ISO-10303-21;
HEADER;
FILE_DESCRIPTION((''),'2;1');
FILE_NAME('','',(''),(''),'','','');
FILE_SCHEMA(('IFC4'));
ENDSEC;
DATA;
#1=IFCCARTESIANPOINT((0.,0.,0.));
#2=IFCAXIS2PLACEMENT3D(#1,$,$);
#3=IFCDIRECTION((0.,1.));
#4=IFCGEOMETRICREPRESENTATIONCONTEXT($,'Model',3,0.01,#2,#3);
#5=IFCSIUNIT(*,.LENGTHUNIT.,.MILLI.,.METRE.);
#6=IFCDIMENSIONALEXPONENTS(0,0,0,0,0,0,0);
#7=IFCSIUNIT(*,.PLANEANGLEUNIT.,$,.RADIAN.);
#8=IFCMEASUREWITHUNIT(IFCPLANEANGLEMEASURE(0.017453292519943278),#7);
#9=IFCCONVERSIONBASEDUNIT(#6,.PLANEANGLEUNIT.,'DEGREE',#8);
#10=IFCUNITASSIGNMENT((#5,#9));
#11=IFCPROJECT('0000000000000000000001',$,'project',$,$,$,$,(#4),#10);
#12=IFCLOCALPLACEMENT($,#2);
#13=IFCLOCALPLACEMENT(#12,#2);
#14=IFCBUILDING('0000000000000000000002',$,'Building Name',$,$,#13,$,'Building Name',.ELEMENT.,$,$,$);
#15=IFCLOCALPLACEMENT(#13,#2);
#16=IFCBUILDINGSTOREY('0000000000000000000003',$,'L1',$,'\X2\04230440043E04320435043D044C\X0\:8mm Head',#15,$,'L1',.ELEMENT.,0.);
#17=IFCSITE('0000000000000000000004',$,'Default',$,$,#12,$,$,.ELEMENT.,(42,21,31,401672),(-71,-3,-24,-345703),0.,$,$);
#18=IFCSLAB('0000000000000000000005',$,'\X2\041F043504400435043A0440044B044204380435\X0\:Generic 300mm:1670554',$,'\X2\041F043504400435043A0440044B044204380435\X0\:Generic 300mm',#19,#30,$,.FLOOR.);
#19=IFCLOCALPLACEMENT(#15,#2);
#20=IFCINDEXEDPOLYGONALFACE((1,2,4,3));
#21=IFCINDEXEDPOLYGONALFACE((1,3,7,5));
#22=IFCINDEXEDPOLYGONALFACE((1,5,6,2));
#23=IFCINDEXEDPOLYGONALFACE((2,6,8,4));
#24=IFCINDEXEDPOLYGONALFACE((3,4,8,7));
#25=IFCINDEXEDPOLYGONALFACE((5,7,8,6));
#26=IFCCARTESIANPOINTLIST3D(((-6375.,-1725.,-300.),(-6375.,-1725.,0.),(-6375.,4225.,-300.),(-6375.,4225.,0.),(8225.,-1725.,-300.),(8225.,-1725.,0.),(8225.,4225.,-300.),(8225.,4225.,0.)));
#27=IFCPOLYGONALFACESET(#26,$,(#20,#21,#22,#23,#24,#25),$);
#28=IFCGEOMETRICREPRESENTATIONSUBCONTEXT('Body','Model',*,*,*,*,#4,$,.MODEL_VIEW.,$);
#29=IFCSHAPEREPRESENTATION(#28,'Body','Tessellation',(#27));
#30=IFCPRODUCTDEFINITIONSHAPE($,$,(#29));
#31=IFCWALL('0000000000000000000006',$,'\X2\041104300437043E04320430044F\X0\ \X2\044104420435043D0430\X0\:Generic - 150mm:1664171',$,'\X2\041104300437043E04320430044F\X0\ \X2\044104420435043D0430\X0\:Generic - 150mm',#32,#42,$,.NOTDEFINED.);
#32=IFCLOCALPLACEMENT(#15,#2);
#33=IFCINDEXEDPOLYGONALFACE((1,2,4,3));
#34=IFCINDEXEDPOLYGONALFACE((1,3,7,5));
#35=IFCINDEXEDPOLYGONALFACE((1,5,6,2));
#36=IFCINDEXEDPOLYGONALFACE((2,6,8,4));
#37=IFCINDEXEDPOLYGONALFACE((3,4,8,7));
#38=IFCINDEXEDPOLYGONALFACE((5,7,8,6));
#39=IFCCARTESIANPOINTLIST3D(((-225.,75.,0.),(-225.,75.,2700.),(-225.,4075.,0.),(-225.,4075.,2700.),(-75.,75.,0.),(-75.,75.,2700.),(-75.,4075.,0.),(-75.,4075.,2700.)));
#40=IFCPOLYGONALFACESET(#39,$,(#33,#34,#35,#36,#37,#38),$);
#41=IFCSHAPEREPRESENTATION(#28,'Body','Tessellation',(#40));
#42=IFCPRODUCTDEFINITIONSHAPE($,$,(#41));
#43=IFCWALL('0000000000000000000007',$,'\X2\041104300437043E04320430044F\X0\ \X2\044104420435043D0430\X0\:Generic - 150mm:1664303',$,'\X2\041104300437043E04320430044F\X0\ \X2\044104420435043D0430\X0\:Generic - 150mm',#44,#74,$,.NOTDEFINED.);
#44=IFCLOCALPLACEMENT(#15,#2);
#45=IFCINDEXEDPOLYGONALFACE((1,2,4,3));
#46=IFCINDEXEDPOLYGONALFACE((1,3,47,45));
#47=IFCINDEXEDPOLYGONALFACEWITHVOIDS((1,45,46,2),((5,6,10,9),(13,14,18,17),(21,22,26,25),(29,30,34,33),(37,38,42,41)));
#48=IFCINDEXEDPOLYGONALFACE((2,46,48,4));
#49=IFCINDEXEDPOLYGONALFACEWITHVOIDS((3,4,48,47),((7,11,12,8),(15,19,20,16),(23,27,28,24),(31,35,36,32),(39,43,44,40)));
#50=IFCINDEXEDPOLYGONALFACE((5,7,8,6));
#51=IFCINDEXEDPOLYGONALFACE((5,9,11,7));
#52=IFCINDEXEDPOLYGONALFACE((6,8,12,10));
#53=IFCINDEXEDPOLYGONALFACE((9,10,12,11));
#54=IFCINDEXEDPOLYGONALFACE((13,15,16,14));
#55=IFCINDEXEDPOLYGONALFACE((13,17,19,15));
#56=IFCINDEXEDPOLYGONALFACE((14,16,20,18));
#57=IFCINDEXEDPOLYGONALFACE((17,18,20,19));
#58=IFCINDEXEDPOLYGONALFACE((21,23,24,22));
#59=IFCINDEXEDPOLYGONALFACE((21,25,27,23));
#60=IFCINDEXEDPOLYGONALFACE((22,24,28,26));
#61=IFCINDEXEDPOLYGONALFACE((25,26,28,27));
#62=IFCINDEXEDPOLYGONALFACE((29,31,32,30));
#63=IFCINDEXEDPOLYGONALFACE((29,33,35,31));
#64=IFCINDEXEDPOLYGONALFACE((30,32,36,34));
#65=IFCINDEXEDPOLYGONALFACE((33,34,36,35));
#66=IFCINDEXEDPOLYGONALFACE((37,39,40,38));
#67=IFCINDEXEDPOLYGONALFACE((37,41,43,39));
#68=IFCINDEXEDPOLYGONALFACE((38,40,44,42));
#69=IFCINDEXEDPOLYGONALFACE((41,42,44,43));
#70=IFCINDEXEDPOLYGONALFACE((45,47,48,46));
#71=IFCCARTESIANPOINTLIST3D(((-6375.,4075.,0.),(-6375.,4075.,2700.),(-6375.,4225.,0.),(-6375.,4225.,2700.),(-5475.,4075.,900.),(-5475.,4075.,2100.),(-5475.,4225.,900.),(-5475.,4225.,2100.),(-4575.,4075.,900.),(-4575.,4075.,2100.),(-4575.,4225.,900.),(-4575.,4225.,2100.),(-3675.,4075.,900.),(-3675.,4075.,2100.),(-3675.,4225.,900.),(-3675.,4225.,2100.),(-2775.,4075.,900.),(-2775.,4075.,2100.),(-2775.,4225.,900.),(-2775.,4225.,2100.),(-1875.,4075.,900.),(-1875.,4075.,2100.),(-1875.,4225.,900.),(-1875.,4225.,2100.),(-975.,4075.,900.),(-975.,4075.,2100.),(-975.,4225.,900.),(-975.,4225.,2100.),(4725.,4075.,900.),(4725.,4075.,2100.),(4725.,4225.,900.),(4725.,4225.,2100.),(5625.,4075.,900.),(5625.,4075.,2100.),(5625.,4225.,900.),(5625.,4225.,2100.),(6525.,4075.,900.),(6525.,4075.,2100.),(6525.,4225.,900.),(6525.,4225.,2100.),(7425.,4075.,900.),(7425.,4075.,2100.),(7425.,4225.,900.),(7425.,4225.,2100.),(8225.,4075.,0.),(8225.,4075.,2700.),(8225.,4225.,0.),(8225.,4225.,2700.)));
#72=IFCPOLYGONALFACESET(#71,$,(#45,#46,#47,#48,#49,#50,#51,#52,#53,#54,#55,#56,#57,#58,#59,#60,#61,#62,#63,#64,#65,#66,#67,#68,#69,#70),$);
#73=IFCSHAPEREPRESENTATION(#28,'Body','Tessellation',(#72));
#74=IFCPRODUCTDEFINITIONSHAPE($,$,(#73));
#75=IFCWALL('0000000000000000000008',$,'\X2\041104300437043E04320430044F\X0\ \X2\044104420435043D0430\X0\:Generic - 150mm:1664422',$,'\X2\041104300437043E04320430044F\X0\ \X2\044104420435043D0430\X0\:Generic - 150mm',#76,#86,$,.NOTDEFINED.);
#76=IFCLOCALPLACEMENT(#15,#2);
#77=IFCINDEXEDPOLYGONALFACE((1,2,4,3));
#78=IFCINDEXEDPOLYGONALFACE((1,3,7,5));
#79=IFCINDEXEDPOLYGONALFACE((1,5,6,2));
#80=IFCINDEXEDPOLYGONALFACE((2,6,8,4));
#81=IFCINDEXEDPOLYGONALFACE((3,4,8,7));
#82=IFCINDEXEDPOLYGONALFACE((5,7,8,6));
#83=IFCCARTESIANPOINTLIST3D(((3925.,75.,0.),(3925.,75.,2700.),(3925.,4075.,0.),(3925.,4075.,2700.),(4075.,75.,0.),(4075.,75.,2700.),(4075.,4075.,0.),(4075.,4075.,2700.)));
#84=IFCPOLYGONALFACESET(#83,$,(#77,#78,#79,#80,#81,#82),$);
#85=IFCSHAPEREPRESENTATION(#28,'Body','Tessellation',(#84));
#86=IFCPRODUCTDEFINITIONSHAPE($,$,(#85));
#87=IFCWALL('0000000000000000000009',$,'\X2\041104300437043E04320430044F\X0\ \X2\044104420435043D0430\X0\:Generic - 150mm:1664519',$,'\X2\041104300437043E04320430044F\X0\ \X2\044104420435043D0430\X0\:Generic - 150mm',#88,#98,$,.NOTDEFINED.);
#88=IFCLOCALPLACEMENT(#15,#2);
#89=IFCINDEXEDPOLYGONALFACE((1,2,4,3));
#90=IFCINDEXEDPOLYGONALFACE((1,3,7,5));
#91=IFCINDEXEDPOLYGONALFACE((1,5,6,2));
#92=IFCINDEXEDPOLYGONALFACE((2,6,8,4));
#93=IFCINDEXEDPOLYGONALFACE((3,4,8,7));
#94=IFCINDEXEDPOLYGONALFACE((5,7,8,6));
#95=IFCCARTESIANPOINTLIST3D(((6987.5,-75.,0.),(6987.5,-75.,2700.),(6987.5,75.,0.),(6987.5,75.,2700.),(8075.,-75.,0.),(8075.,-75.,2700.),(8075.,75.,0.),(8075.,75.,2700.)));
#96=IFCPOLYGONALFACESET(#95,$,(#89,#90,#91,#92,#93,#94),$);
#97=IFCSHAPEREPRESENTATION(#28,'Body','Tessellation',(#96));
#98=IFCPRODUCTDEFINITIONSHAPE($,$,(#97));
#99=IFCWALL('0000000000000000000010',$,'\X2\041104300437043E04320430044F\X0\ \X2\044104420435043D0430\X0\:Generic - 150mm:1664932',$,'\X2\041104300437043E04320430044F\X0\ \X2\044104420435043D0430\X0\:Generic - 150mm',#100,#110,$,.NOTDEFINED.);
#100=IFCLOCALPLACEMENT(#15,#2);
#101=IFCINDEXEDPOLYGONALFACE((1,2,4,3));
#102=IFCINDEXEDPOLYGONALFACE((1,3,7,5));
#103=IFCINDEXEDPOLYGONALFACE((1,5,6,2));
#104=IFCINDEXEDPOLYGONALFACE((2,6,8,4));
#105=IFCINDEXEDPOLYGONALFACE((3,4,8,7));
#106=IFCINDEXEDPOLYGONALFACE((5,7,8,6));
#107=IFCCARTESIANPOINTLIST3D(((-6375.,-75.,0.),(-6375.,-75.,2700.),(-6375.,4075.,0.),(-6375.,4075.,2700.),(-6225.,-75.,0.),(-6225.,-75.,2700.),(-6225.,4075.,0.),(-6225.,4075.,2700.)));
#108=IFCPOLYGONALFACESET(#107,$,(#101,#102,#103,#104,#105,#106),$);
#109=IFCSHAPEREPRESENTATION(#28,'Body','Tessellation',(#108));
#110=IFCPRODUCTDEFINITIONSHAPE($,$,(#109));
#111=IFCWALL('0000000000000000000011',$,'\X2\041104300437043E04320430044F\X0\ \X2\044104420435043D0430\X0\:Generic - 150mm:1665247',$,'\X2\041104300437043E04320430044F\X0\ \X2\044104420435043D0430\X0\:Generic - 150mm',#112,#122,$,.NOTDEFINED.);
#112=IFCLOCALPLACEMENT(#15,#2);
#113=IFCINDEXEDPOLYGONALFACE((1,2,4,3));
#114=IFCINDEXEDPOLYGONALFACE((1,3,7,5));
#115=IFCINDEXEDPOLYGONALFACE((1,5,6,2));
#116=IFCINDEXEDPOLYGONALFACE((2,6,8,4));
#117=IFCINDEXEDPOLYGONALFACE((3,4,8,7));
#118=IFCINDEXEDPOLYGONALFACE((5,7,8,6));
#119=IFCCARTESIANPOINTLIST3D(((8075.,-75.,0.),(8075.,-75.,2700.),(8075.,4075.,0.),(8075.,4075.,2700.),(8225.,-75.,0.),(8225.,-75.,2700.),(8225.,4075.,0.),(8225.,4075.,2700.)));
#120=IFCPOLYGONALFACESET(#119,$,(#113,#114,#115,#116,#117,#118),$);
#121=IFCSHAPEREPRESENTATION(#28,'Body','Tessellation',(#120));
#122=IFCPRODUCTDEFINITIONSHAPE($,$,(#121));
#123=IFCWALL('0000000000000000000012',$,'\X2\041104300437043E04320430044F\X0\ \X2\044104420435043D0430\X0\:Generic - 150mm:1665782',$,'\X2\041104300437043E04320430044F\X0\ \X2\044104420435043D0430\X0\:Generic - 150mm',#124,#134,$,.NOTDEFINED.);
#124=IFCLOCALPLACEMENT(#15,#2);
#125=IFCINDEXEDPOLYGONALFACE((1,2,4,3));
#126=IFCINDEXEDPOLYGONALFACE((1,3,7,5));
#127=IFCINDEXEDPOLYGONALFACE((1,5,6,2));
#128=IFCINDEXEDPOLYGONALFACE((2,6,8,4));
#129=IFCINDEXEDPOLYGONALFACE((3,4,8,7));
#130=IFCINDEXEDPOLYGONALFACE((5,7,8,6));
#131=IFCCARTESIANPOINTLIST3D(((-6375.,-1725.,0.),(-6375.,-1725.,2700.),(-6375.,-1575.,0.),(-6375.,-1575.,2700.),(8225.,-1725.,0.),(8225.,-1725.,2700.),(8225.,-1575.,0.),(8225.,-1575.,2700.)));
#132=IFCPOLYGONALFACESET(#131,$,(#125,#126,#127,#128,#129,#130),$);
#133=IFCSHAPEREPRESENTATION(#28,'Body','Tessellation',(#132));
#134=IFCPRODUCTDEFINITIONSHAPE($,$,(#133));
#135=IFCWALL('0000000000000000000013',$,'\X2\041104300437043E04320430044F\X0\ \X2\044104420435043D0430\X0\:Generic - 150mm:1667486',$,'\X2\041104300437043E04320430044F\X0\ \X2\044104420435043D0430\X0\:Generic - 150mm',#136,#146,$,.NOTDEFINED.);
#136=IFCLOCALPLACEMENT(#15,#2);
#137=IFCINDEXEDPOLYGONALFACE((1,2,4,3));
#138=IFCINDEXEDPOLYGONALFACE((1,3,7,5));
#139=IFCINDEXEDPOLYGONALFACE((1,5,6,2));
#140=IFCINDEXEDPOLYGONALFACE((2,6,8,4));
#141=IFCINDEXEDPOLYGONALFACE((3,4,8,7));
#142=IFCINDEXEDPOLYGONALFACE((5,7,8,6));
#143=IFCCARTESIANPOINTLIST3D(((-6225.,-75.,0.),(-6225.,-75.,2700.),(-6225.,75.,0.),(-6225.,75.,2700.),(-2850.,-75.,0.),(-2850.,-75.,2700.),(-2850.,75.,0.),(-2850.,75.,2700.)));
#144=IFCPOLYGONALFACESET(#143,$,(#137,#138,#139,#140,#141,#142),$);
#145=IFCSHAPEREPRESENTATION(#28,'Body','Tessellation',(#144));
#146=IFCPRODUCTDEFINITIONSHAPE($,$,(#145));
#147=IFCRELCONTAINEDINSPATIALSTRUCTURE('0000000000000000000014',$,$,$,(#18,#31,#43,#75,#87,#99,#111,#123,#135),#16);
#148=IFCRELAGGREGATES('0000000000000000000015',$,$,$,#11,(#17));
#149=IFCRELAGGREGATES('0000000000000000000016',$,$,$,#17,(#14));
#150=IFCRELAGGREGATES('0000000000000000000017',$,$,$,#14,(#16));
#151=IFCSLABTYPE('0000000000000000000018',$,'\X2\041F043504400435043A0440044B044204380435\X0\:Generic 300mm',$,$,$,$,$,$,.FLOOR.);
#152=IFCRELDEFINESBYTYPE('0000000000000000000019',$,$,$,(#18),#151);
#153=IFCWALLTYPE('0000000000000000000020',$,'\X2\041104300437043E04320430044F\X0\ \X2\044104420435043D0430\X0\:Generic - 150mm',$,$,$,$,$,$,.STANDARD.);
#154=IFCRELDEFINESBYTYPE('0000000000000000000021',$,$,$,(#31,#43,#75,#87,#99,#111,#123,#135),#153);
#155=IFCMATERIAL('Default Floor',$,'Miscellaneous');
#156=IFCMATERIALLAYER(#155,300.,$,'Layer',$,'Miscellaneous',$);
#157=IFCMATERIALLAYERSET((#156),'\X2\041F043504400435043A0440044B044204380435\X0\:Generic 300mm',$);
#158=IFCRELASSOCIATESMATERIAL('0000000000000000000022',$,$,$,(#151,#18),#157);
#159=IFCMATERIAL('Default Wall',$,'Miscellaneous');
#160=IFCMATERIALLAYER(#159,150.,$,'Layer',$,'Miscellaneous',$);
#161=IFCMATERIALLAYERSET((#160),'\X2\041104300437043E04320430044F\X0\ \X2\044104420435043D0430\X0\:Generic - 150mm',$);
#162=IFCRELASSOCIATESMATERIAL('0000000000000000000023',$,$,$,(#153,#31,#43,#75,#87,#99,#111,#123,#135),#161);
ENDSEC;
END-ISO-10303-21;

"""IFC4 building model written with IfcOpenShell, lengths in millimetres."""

from ifc_helpers import new_model, entity, si_unit, converted_unit, direction, frame, frame_2d, origin, origin_2d_with_axis, place, context, subcontext, project, spatial, rectangle, extrude, material, layer, layer_set, layer_usage, type_object, element, save


model = new_model("IFC4")

# Units and contexts
model_context = context("Model", 3, precision=0.01, world=origin(), true_north=direction((0.0, 1.0)))
body_context = subcontext(model_context, "Body", "Model", "MODEL_VIEW")
ifc_project = project(units=[si_unit("LENGTHUNIT", "METRE", prefix="MILLI"), converted_unit("PLANEANGLEUNIT", "DEGREE", entity("IfcPlaneAngleMeasure", 0.017453292519943278), si_unit("PLANEANGLEUNIT", "RADIAN"), dimensions=[0, 0, 0, 0, 0, 0, 0])], contexts=[model_context])

# Site, building, storey
site_placement = place(None, origin())
site = spatial("IfcSite", under=ifc_project, at=site_placement, Name="Default", CompositionType="ELEMENT", RefLatitude=(42, 21, 31, 401672), RefLongitude=(-71, -3, -24, -345703), RefElevation=0.0)
building_placement = place(site_placement, origin())
building = spatial("IfcBuilding", under=site, at=building_placement, Name="Building Name", LongName="Building Name", CompositionType="ELEMENT")
storey_placement = place(building_placement, origin())
storey = spatial("IfcBuildingStorey", under=building, at=storey_placement, Name="L1", ObjectType="Уровень:8mm Head", LongName="L1", CompositionType="ELEMENT", Elevation=0.0)

# Slab
ifc_material_1 = material(Name="Default Floor", Category="Miscellaneous")
ifc_layer_1 = layer(ifc_material_1, 300.0, Name="Layer", Category="Miscellaneous")
ifc_layer_set_1 = layer_set([ifc_layer_1], Name="Перекрытие:Generic 300mm")
ifc_layer_usage_1 = layer_usage(ifc_layer_set_1, "AXIS3", "POSITIVE", 0.0)
slab_type = type_object("IfcSlabType", Name="Перекрытие:Generic 300mm", PredefinedType="FLOOR", material=ifc_layer_set_1)
slab_placement = place(storey_placement, origin())
element("IfcSlab", 1, at=slab_placement, inside=storey, type_object=slab_type, material=ifc_layer_usage_1, Name="Перекрытие:Generic 300mm:1670554", ObjectType="Перекрытие:Generic 300mm", PredefinedType="FLOOR", context=body_context, shape_type="SweptSolid", body=[
    extrude(rectangle(XDim=5950.0, YDim=14600.0, at=origin_2d_with_axis()), frame((925.0, 1250.0, 0.0), z_axis=(0.0, 0.0, -1.0), x_axis=(0.0, 1.0, 0.0)), (0.0, 0.0, 1.0), 300.0),
])

# Wall
ifc_material_2 = material(Name="Default Wall", Category="Miscellaneous")
ifc_layer_2 = layer(ifc_material_2, 150.0, Name="Layer", Category="Miscellaneous")
ifc_layer_set_2 = layer_set([ifc_layer_2], Name="Базовая стена:Generic - 150mm")
ifc_layer_usage_2 = layer_usage(ifc_layer_set_2, "AXIS2", "NEGATIVE", 75.0)
wall_type = type_object("IfcWallType", Name="Базовая стена:Generic - 150mm", PredefinedType="STANDARD", material=ifc_layer_set_2)
wall_1_placement = place(storey_placement, frame((-150.0, 75.0, 0.0), z_axis=(0.0, 0.0, 1.0), x_axis=(0.0, 1.0, 0.0)))
element("IfcWall", 2, at=wall_1_placement, inside=storey, type_object=wall_type, material=ifc_layer_usage_2, Name="Базовая стена:Generic - 150mm:1664171", ObjectType="Базовая стена:Generic - 150mm", PredefinedType="NOTDEFINED", context=body_context, shape_type="SweptSolid", body=[
    extrude(rectangle(XDim=4000.0, YDim=150.0, at=frame_2d((2000.0, 0.0), x_axis=(-1.0, 0.0))), origin(), (0.0, 0.0, 1.0), 2700.0),
])

# Wall, openings
ifc_layer_usage_3 = layer_usage(ifc_layer_set_2, "AXIS2", "NEGATIVE", 75.0)
wall_2_placement = place(storey_placement, frame((-6375.0, 4150.0, 0.0)))
wall_2 = element("IfcWall", 3, at=wall_2_placement, inside=storey, type_object=wall_type, material=ifc_layer_usage_3, Name="Базовая стена:Generic - 150mm:1664303", ObjectType="Базовая стена:Generic - 150mm", PredefinedType="NOTDEFINED", context=body_context, shape_type="SweptSolid", body=[
    extrude(rectangle(XDim=14600.0, YDim=150.0, at=frame_2d((7300.0, 0.0), x_axis=(-1.0, 0.0))), origin(), (0.0, 0.0, 1.0), 2700.0),
])
opening_1_placement = place(wall_2_placement, frame((4500.0, -75.0, 900.0)))
element("IfcOpeningElement", 4, at=opening_1_placement, cuts=wall_2, PredefinedType="OPENING", context=body_context, shape_type="SweptSolid", body=[
    extrude(rectangle(XDim=1200.0, YDim=900.0, at=frame_2d((600.0, 450.0), x_axis=(-1.0, 0.0))), frame((0.0, 0.0, 0.0), z_axis=(0.0, 1.0, 0.0), x_axis=(0.0, 0.0, 1.0)), (0.0, 0.0, 1.0), 150.0),
])
opening_2_placement = place(wall_2_placement, frame((2700.0, -75.0, 900.0)))
element("IfcOpeningElement", 5, at=opening_2_placement, cuts=wall_2, PredefinedType="OPENING", context=body_context, shape_type="SweptSolid", body=[
    extrude(rectangle(XDim=1200.0, YDim=900.0, at=frame_2d((600.0, 450.0), x_axis=(-1.0, 0.0))), frame((0.0, 0.0, 0.0), z_axis=(0.0, 1.0, 0.0), x_axis=(0.0, 0.0, 1.0)), (0.0, 0.0, 1.0), 150.0),
])
opening_3_placement = place(wall_2_placement, frame((900.0, -75.0, 900.0)))
element("IfcOpeningElement", 6, at=opening_3_placement, cuts=wall_2, PredefinedType="OPENING", context=body_context, shape_type="SweptSolid", body=[
    extrude(rectangle(XDim=1200.0, YDim=900.0, at=frame_2d((600.0, 450.0), x_axis=(-1.0, 0.0))), frame((0.0, 0.0, 0.0), z_axis=(0.0, 1.0, 0.0), x_axis=(0.0, 0.0, 1.0)), (0.0, 0.0, 1.0), 150.0),
])
opening_4_placement = place(wall_2_placement, frame((11100.0, -75.0, 900.0)))
element("IfcOpeningElement", 7, at=opening_4_placement, cuts=wall_2, PredefinedType="OPENING", context=body_context, shape_type="SweptSolid", body=[
    extrude(rectangle(XDim=1200.0, YDim=900.0, at=frame_2d((600.0, 450.0), x_axis=(-1.0, 0.0))), frame((0.0, 0.0, 0.0), z_axis=(0.0, 1.0, 0.0), x_axis=(0.0, 0.0, 1.0)), (0.0, 0.0, 1.0), 150.0),
])
opening_5_placement = place(wall_2_placement, frame((12900.0, -75.0, 900.0)))
element("IfcOpeningElement", 8, at=opening_5_placement, cuts=wall_2, PredefinedType="OPENING", context=body_context, shape_type="SweptSolid", body=[
    extrude(rectangle(XDim=1200.0, YDim=900.0, at=frame_2d((600.0, 450.0), x_axis=(-1.0, 0.0))), frame((0.0, 0.0, 0.0), z_axis=(0.0, 1.0, 0.0), x_axis=(0.0, 0.0, 1.0)), (0.0, 0.0, 1.0), 150.0),
])

# Walls
ifc_layer_usage_4 = layer_usage(ifc_layer_set_2, "AXIS2", "NEGATIVE", 75.0)
wall_3_placement = place(storey_placement, frame((4000.0, 4075.0, 0.0), z_axis=(0.0, 0.0, 1.0), x_axis=(0.0, -1.0, 0.0)))
element("IfcWall", 9, at=wall_3_placement, inside=storey, type_object=wall_type, material=ifc_layer_usage_4, Name="Базовая стена:Generic - 150mm:1664422", ObjectType="Базовая стена:Generic - 150mm", PredefinedType="NOTDEFINED", context=body_context, shape_type="SweptSolid", body=[
    extrude(rectangle(XDim=4000.0, YDim=150.0, at=frame_2d((2000.0, 0.0), x_axis=(-1.0, 0.0))), origin(), (0.0, 0.0, 1.0), 2700.0),
])
ifc_layer_usage_5 = layer_usage(ifc_layer_set_2, "AXIS2", "NEGATIVE", 75.0)
wall_4_placement = place(storey_placement, frame((8075.0, 0.0, 0.0), z_axis=(0.0, 0.0, 1.0), x_axis=(-1.0, 0.0, 0.0)))
element("IfcWall", 10, at=wall_4_placement, inside=storey, type_object=wall_type, material=ifc_layer_usage_5, Name="Базовая стена:Generic - 150mm:1664519", ObjectType="Базовая стена:Generic - 150mm", PredefinedType="NOTDEFINED", context=body_context, shape_type="SweptSolid", body=[
    extrude(rectangle(XDim=1087.5, YDim=150.0, at=frame_2d((543.7, 0.0), x_axis=(-1.0, 0.0))), origin(), (0.0, 0.0, 1.0), 2700.0),
])
ifc_layer_usage_6 = layer_usage(ifc_layer_set_2, "AXIS2", "NEGATIVE", 75.0)
wall_5_placement = place(storey_placement, frame((-6300.0, 4075.0, 0.0), z_axis=(0.0, 0.0, 1.0), x_axis=(0.0, -1.0, 0.0)))
element("IfcWall", 11, at=wall_5_placement, inside=storey, type_object=wall_type, material=ifc_layer_usage_6, Name="Базовая стена:Generic - 150mm:1664932", ObjectType="Базовая стена:Generic - 150mm", PredefinedType="NOTDEFINED", context=body_context, shape_type="SweptSolid", body=[
    extrude(rectangle(XDim=4150.0, YDim=150.0, at=frame_2d((2075.0, 0.0), x_axis=(-1.0, 0.0))), origin(), (0.0, 0.0, 1.0), 2700.0),
])
ifc_layer_usage_7 = layer_usage(ifc_layer_set_2, "AXIS2", "NEGATIVE", 75.0)
wall_6_placement = place(storey_placement, frame((8150.0, 4075.0, 0.0), z_axis=(0.0, 0.0, 1.0), x_axis=(0.0, -1.0, 0.0)))
element("IfcWall", 12, at=wall_6_placement, inside=storey, type_object=wall_type, material=ifc_layer_usage_7, Name="Базовая стена:Generic - 150mm:1665247", ObjectType="Базовая стена:Generic - 150mm", PredefinedType="NOTDEFINED", context=body_context, shape_type="SweptSolid", body=[
    extrude(rectangle(XDim=4150.0, YDim=150.0, at=frame_2d((2075.0, 0.0), x_axis=(-1.0, 0.0))), origin(), (0.0, 0.0, 1.0), 2700.0),
])
ifc_layer_usage_8 = layer_usage(ifc_layer_set_2, "AXIS2", "NEGATIVE", 75.0)
wall_7_placement = place(storey_placement, frame((8225.0, -1650.0, 0.0), z_axis=(0.0, 0.0, 1.0), x_axis=(-1.0, 0.0, 0.0)))
element("IfcWall", 13, at=wall_7_placement, inside=storey, type_object=wall_type, material=ifc_layer_usage_8, Name="Базовая стена:Generic - 150mm:1665782", ObjectType="Базовая стена:Generic - 150mm", PredefinedType="NOTDEFINED", context=body_context, shape_type="SweptSolid", body=[
    extrude(rectangle(XDim=14600.0, YDim=150.0, at=frame_2d((7300.0, 0.0), x_axis=(-1.0, 0.0))), origin(), (0.0, 0.0, 1.0), 2700.0),
])
ifc_layer_usage_9 = layer_usage(ifc_layer_set_2, "AXIS2", "NEGATIVE", 75.0)
wall_8_placement = place(storey_placement, frame((-2850.0, 0.0, 0.0), z_axis=(0.0, 0.0, 1.0), x_axis=(-1.0, 0.0, 0.0)))
element("IfcWall", 14, at=wall_8_placement, inside=storey, type_object=wall_type, material=ifc_layer_usage_9, Name="Базовая стена:Generic - 150mm:1667486", ObjectType="Базовая стена:Generic - 150mm", PredefinedType="NOTDEFINED", context=body_context, shape_type="SweptSolid", body=[
    extrude(rectangle(XDim=3375.0, YDim=150.0, at=frame_2d((1687.5, 0.0), x_axis=(-1.0, 0.0))), origin(), (0.0, 0.0, 1.0), 2700.0),
])

save(model, "model.ifc")
